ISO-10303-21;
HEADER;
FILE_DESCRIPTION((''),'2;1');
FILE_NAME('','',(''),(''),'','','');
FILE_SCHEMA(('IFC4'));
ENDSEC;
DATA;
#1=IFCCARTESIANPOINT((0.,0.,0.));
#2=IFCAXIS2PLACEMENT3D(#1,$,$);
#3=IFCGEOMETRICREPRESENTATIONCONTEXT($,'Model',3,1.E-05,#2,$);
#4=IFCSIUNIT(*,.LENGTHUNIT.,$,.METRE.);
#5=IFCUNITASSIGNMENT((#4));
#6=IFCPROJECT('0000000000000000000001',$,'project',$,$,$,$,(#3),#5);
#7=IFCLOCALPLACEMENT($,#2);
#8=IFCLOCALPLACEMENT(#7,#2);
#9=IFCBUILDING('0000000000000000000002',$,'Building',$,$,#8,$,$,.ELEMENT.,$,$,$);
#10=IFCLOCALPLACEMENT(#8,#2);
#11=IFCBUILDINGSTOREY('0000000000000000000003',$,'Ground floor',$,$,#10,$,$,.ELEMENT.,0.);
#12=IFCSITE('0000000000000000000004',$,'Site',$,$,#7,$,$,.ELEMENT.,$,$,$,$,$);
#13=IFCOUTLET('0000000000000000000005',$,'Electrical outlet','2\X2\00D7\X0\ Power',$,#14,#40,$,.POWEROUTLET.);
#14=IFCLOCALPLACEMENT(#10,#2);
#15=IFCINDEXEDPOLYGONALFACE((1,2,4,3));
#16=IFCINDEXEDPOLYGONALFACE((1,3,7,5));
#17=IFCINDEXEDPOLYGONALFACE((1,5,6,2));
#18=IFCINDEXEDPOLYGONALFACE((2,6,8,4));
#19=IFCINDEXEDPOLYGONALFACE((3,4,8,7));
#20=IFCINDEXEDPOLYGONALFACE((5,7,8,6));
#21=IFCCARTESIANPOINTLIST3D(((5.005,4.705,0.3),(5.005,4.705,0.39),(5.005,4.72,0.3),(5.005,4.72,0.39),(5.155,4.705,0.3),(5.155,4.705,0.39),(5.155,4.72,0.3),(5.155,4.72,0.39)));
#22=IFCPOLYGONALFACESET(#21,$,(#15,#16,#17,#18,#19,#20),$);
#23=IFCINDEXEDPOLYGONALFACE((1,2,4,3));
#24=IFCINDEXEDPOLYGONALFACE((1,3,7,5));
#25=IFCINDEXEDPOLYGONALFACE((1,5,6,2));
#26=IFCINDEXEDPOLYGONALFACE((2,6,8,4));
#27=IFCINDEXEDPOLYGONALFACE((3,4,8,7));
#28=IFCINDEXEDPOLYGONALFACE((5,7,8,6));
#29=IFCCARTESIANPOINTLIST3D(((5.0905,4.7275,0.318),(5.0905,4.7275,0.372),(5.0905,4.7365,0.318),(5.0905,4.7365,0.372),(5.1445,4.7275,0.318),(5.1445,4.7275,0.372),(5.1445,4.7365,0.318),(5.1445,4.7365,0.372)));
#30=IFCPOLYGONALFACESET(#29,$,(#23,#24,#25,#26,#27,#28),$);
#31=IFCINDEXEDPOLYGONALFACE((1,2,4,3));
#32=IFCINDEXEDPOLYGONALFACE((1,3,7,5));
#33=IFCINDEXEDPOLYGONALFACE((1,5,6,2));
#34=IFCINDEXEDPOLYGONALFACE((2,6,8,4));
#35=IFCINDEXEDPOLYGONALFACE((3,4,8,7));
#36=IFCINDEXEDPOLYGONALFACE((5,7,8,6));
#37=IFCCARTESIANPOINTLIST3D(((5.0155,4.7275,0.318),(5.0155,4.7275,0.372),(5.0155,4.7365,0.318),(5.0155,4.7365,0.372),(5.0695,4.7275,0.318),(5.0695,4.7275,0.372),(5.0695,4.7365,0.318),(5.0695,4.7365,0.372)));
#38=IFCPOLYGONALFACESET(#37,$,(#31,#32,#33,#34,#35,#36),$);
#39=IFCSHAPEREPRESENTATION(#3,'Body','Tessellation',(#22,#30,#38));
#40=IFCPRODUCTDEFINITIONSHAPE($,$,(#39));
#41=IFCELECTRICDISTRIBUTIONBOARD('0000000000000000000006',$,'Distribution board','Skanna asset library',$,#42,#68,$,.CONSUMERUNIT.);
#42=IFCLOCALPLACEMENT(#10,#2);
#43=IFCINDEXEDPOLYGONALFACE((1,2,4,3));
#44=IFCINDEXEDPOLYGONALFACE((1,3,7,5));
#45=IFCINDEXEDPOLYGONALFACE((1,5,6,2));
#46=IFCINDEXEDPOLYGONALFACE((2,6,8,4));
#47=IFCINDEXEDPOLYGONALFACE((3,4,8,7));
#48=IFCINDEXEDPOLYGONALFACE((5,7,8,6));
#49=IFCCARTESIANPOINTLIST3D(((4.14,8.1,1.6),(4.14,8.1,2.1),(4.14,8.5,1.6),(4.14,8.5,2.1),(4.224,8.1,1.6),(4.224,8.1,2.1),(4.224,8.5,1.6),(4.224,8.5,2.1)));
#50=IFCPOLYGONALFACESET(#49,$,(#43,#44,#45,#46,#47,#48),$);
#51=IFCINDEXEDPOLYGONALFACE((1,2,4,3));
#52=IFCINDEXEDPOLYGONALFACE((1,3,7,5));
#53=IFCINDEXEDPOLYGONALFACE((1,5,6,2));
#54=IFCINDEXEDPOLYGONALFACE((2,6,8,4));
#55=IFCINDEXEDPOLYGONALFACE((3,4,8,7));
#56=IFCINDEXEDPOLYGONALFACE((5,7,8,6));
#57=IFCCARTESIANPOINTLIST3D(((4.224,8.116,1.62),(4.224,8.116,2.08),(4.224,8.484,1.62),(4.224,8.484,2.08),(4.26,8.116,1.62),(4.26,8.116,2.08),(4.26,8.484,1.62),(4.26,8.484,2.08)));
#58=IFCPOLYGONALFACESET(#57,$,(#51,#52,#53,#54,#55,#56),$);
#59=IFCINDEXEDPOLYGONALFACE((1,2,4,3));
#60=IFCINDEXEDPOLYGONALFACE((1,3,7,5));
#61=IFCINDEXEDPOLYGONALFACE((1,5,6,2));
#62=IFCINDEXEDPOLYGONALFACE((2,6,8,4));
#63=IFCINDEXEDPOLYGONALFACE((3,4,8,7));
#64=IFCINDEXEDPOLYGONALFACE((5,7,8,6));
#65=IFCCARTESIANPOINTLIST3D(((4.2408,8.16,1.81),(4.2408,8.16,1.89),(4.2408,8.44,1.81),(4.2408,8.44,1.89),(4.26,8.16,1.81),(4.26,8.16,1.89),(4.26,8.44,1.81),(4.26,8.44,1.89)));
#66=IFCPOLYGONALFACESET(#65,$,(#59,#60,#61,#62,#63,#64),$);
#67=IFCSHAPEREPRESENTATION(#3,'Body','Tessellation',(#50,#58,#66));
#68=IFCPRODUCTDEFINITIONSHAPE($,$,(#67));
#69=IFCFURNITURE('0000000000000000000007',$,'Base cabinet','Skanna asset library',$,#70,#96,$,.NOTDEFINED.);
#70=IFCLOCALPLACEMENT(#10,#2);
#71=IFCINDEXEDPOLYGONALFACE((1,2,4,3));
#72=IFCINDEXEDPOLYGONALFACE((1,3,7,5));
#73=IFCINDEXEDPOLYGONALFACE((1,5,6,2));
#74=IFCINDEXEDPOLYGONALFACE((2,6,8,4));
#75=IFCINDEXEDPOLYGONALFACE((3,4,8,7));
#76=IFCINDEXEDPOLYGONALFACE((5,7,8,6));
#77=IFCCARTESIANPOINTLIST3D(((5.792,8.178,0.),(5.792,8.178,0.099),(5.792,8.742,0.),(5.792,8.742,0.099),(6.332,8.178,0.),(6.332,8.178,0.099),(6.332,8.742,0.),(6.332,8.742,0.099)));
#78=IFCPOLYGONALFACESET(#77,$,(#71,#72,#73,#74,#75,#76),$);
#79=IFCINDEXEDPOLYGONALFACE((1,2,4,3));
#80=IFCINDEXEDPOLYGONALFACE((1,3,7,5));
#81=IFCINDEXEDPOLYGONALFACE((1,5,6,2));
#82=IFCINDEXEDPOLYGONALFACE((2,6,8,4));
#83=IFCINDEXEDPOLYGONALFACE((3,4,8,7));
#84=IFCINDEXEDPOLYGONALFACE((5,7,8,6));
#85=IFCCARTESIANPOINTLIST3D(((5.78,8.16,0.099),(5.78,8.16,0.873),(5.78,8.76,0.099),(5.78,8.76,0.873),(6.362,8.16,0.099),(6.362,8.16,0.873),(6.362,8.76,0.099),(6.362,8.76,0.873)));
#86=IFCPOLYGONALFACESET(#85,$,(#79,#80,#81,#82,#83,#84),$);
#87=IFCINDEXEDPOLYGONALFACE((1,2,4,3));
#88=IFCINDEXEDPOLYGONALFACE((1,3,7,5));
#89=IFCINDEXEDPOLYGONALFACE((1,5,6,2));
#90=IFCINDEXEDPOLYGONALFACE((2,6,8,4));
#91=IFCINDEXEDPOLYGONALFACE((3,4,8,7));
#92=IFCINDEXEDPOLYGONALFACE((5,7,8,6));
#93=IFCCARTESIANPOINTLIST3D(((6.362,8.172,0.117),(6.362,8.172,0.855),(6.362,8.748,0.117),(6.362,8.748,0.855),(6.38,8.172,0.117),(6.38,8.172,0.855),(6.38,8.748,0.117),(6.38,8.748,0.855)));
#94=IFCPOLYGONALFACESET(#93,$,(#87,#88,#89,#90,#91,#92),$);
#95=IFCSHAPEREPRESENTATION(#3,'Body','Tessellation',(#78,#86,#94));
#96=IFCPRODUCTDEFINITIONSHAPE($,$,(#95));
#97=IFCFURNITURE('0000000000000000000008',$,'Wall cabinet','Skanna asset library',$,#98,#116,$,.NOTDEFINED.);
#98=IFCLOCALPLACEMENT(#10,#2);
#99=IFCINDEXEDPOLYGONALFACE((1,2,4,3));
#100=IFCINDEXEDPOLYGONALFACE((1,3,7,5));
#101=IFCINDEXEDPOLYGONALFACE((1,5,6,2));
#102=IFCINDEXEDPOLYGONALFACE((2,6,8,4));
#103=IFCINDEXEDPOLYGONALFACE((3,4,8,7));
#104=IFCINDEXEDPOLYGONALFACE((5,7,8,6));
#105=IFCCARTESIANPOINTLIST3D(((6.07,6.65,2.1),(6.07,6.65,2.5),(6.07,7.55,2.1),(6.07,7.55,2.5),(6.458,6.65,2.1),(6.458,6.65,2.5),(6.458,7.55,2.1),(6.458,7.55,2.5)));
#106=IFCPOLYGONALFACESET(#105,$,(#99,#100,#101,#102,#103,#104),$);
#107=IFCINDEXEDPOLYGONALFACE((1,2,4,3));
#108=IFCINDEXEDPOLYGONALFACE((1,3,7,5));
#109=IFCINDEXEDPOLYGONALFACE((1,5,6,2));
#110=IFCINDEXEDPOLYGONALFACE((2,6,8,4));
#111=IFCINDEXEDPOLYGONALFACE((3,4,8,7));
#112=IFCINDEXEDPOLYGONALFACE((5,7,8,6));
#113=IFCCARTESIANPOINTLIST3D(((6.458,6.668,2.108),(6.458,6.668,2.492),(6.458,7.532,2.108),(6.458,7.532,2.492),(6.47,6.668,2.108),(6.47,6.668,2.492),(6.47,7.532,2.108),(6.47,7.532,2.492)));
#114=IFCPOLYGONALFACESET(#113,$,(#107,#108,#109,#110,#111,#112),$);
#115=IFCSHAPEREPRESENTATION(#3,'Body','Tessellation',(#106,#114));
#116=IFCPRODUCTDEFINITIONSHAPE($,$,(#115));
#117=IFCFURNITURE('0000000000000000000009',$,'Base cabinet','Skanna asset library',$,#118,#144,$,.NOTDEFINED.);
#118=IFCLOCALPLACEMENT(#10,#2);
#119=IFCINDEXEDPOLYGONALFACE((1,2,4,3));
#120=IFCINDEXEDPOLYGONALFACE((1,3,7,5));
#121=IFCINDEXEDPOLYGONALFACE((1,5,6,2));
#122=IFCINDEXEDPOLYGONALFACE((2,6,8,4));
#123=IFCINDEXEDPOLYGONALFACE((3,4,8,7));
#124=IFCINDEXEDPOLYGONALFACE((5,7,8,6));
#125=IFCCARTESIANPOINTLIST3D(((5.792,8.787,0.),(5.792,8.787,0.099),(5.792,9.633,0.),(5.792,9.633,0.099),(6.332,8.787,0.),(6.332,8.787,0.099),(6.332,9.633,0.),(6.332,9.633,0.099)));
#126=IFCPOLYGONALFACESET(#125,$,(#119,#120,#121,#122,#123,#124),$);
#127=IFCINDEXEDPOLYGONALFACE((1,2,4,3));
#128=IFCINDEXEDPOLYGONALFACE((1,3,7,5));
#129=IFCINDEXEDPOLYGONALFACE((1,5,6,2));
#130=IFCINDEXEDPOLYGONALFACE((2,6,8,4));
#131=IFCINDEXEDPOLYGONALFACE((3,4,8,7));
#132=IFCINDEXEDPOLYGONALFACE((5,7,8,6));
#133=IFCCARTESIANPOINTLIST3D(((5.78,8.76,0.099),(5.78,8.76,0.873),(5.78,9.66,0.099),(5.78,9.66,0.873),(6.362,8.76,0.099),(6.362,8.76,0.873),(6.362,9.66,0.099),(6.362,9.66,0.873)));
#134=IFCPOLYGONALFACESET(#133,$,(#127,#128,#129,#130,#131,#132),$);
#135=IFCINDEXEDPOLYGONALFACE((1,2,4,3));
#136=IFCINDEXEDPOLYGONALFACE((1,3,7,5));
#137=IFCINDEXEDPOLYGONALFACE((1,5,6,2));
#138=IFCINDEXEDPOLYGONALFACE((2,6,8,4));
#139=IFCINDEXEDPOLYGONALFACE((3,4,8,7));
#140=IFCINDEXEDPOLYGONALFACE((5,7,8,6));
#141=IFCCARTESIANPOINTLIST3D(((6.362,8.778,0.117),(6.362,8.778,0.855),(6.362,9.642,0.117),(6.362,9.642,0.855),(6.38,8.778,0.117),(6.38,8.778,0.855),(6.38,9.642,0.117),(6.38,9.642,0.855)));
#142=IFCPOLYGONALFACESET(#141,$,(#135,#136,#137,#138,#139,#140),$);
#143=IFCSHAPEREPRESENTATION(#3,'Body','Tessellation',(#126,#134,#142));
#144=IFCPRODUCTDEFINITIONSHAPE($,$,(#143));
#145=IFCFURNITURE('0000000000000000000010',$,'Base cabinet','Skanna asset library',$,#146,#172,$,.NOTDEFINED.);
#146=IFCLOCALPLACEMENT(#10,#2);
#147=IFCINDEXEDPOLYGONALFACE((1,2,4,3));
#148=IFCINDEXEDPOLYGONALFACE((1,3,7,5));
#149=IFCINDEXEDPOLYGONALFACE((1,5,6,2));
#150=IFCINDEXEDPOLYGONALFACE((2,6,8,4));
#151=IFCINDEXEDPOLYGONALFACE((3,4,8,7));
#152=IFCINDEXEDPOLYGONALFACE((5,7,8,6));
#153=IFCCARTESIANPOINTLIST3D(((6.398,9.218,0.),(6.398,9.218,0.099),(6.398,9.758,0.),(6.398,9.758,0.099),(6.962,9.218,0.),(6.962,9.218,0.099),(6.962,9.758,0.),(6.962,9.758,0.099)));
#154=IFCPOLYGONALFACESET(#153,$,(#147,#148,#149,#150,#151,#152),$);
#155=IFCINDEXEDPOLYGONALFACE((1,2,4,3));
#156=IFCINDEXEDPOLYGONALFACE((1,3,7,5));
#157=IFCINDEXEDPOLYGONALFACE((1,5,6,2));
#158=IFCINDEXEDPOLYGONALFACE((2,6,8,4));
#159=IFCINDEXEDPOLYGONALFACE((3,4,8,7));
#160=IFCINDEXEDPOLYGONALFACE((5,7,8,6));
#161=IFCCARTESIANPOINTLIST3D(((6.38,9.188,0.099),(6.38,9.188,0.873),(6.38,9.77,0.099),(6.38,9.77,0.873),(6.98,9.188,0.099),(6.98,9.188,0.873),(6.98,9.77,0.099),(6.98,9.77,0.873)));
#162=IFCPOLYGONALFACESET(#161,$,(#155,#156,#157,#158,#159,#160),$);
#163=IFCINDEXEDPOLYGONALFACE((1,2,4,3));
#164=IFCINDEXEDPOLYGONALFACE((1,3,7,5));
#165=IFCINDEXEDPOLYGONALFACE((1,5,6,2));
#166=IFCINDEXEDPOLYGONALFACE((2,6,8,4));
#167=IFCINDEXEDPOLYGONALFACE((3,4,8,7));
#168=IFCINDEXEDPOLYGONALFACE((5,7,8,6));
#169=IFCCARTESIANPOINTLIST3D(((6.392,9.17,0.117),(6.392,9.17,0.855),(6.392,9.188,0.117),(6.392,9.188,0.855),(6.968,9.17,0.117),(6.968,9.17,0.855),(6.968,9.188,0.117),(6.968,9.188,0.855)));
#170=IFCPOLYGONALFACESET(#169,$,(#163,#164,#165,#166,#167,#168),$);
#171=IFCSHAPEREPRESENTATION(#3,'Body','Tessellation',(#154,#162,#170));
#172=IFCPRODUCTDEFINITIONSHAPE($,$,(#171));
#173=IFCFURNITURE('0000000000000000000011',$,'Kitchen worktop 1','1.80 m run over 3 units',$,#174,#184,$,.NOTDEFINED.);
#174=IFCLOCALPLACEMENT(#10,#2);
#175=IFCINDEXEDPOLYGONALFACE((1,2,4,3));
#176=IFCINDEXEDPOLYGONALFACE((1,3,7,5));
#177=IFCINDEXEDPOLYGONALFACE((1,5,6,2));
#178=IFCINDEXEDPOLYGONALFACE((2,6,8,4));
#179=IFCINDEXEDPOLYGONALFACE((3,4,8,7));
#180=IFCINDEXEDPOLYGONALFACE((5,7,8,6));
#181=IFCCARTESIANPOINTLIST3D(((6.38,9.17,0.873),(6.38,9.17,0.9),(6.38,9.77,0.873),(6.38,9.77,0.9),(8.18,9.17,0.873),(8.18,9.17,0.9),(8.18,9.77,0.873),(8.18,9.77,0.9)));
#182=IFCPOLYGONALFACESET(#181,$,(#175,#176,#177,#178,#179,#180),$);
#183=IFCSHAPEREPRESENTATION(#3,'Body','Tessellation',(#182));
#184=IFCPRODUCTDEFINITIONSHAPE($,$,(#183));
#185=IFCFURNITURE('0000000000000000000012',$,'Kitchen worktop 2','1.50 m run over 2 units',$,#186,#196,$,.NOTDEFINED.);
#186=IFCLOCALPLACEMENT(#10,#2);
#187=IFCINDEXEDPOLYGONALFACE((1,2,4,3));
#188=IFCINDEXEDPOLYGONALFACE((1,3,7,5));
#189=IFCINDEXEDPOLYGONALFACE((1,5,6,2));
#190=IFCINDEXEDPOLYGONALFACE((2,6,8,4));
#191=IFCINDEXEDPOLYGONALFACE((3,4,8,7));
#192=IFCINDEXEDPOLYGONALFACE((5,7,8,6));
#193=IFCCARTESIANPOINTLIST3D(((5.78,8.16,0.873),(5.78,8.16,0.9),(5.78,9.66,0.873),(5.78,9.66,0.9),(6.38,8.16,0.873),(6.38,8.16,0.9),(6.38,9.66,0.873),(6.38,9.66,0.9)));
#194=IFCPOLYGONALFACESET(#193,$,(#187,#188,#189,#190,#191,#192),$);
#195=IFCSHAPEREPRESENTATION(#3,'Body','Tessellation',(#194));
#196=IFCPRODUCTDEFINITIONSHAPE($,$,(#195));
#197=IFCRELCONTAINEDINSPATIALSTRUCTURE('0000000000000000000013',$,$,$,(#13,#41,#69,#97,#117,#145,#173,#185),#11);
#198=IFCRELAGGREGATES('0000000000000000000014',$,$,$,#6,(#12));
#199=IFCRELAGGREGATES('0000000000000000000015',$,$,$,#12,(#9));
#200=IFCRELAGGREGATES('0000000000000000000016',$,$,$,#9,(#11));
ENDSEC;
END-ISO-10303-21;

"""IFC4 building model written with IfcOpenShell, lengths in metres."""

from ifc_helpers import new_model, si_unit, frame, frame_2d, origin, origin_2d, place, context, project, spatial, rectangle, extrude, element, save


model = new_model("IFC4")

# Units and contexts
model_context = context("Model", 3, precision=1e-05, world=origin())
ifc_project = project(units=[si_unit("LENGTHUNIT", "METRE")], contexts=[model_context])

# Site, building, storey
site_placement = place(None, origin())
site = spatial("IfcSite", under=ifc_project, at=site_placement, Name="Site", CompositionType="ELEMENT")
building_placement = place(site_placement, origin())
building = spatial("IfcBuilding", under=site, at=building_placement, Name="Building", CompositionType="ELEMENT")
storey_placement = place(building_placement, origin())
storey = spatial("IfcBuildingStorey", under=building, at=storey_placement, Name="Ground floor", CompositionType="ELEMENT", Elevation=0.0)

# Outlet
outlet_placement = place(storey_placement, frame((5.08, 4.72, 0.3), z_axis=(0.0, 0.0, 1.0), x_axis=(-1.0, 0.0, 0.0)))
element("IfcOutlet", 1, at=outlet_placement, inside=storey, Name="Electrical outlet", Description="2× Power", PredefinedType="POWEROUTLET", context=model_context, shape_type="SweptSolid", body=[
    extrude(rectangle(XDim=0.15, YDim=0.015, at=frame_2d((0.0, 0.0075))), origin(), (0.0, 0.0, 1.0), 0.09),
    extrude(rectangle(XDim=0.054, YDim=0.009, at=frame_2d((-0.0375, -0.012))), frame((0.0, 0.0, 0.018)), (0.0, 0.0, 1.0), 0.054),
    extrude(rectangle(XDim=0.054, YDim=0.009, at=frame_2d((0.0375, -0.012))), frame((0.0, 0.0, 0.018)), (0.0, 0.0, 1.0), 0.054),
])

# Electric distribution board
electric_distribution_board_placement = place(storey_placement, frame((4.2, 8.3, 1.6), z_axis=(0.0, 0.0, 1.0), x_axis=(0.0, 1.0, 0.0)))
element("IfcElectricDistributionBoard", 2, at=electric_distribution_board_placement, inside=storey, Name="Distribution board", Description="Skanna asset library", PredefinedType="CONSUMERUNIT", context=model_context, shape_type="SweptSolid", body=[
    extrude(rectangle(XDim=0.4, YDim=0.084, at=frame_2d((0.0, 0.018))), origin(), (0.0, 0.0, 1.0), 0.5),
    extrude(rectangle(XDim=0.368, YDim=0.036, at=frame_2d((0.0, -0.042))), frame((0.0, 0.0, 0.02)), (0.0, 0.0, 1.0), 0.46),
    extrude(rectangle(XDim=0.28, YDim=0.0192, at=frame_2d((0.0, -0.0504))), frame((0.0, 0.0, 0.21)), (0.0, 0.0, 1.0), 0.08),
])

# Furniture
furniture_1_placement = place(storey_placement, frame((6.08, 8.46, 0.0), z_axis=(0.0, 0.0, 1.0), x_axis=(0.0, 1.0, 0.0)))
element("IfcFurniture", 3, at=furniture_1_placement, inside=storey, Name="Base cabinet", Description="Skanna asset library", PredefinedType="NOTDEFINED", context=model_context, shape_type="SweptSolid", body=[
    extrude(rectangle(XDim=0.564, YDim=0.54, at=frame_2d((0.0, 0.018))), origin(), (0.0, 0.0, 1.0), 0.099),
    extrude(rectangle(XDim=0.6, YDim=0.582, at=frame_2d((0.0, 0.009))), frame((0.0, 0.0, 0.099)), (0.0, 0.0, 1.0), 0.774),
    extrude(rectangle(XDim=0.576, YDim=0.018, at=frame_2d((0.0, -0.291))), frame((0.0, 0.0, 0.117)), (0.0, 0.0, 1.0), 0.738),
])
furniture_2_placement = place(storey_placement, frame((6.27, 7.1, 2.1), z_axis=(0.0, 0.0, 1.0), x_axis=(0.0, 1.0, 0.0)))
element("IfcFurniture", 4, at=furniture_2_placement, inside=storey, Name="Wall cabinet", Description="Skanna asset library", PredefinedType="NOTDEFINED", context=model_context, shape_type="SweptSolid", body=[
    extrude(rectangle(XDim=0.9, YDim=0.388, at=frame_2d((0.0, 0.006))), origin(), (0.0, 0.0, 1.0), 0.4),
    extrude(rectangle(XDim=0.864, YDim=0.012, at=frame_2d((0.0, -0.194))), frame((0.0, 0.0, 0.008)), (0.0, 0.0, 1.0), 0.384),
])
furniture_3_placement = place(storey_placement, frame((6.08, 9.21, 0.0), z_axis=(0.0, 0.0, 1.0), x_axis=(0.0, 1.0, 0.0)))
element("IfcFurniture", 5, at=furniture_3_placement, inside=storey, Name="Base cabinet", Description="Skanna asset library", PredefinedType="NOTDEFINED", context=model_context, shape_type="SweptSolid", body=[
    extrude(rectangle(XDim=0.846, YDim=0.54, at=frame_2d((0.0, 0.018))), origin(), (0.0, 0.0, 1.0), 0.099),
    extrude(rectangle(XDim=0.9, YDim=0.582, at=frame_2d((0.0, 0.009))), frame((0.0, 0.0, 0.099)), (0.0, 0.0, 1.0), 0.774),
    extrude(rectangle(XDim=0.864, YDim=0.018, at=frame_2d((0.0, -0.291))), frame((0.0, 0.0, 0.117)), (0.0, 0.0, 1.0), 0.738),
])
furniture_4_placement = place(storey_placement, frame((6.68, 9.47, 0.0), z_axis=(0.0, 0.0, 1.0), x_axis=(1.0, 0.0, 0.0)))
element("IfcFurniture", 6, at=furniture_4_placement, inside=storey, Name="Base cabinet", Description="Skanna asset library", PredefinedType="NOTDEFINED", context=model_context, shape_type="SweptSolid", body=[
    extrude(rectangle(XDim=0.564, YDim=0.54, at=frame_2d((0.0, 0.018))), origin(), (0.0, 0.0, 1.0), 0.099),
    extrude(rectangle(XDim=0.6, YDim=0.582, at=frame_2d((0.0, 0.009))), frame((0.0, 0.0, 0.099)), (0.0, 0.0, 1.0), 0.774),
    extrude(rectangle(XDim=0.576, YDim=0.018, at=frame_2d((0.0, -0.291))), frame((0.0, 0.0, 0.117)), (0.0, 0.0, 1.0), 0.738),
])
furniture_5_placement = place(storey_placement, frame((7.28, 9.47, 0.873), z_axis=(0.0, 0.0, 1.0), x_axis=(1.0, 0.0, 0.0)))
element("IfcFurniture", 7, at=furniture_5_placement, inside=storey, Name="Kitchen worktop 1", Description="1.80 m run over 3 units", PredefinedType="NOTDEFINED", context=model_context, shape_type="SweptSolid", body=[
    extrude(rectangle(XDim=1.8, YDim=0.6, at=origin_2d()), origin(), (0.0, 0.0, 1.0), 0.027),
])
furniture_6_placement = place(storey_placement, frame((6.08, 8.91, 0.873), z_axis=(0.0, 0.0, 1.0), x_axis=(0.0, 1.0, 0.0)))
element("IfcFurniture", 8, at=furniture_6_placement, inside=storey, Name="Kitchen worktop 2", Description="1.50 m run over 2 units", PredefinedType="NOTDEFINED", context=model_context, shape_type="SweptSolid", body=[
    extrude(rectangle(XDim=1.5, YDim=0.6, at=origin_2d()), origin(), (0.0, 0.0, 1.0), 0.027),
])

save(model, "model.ifc")
